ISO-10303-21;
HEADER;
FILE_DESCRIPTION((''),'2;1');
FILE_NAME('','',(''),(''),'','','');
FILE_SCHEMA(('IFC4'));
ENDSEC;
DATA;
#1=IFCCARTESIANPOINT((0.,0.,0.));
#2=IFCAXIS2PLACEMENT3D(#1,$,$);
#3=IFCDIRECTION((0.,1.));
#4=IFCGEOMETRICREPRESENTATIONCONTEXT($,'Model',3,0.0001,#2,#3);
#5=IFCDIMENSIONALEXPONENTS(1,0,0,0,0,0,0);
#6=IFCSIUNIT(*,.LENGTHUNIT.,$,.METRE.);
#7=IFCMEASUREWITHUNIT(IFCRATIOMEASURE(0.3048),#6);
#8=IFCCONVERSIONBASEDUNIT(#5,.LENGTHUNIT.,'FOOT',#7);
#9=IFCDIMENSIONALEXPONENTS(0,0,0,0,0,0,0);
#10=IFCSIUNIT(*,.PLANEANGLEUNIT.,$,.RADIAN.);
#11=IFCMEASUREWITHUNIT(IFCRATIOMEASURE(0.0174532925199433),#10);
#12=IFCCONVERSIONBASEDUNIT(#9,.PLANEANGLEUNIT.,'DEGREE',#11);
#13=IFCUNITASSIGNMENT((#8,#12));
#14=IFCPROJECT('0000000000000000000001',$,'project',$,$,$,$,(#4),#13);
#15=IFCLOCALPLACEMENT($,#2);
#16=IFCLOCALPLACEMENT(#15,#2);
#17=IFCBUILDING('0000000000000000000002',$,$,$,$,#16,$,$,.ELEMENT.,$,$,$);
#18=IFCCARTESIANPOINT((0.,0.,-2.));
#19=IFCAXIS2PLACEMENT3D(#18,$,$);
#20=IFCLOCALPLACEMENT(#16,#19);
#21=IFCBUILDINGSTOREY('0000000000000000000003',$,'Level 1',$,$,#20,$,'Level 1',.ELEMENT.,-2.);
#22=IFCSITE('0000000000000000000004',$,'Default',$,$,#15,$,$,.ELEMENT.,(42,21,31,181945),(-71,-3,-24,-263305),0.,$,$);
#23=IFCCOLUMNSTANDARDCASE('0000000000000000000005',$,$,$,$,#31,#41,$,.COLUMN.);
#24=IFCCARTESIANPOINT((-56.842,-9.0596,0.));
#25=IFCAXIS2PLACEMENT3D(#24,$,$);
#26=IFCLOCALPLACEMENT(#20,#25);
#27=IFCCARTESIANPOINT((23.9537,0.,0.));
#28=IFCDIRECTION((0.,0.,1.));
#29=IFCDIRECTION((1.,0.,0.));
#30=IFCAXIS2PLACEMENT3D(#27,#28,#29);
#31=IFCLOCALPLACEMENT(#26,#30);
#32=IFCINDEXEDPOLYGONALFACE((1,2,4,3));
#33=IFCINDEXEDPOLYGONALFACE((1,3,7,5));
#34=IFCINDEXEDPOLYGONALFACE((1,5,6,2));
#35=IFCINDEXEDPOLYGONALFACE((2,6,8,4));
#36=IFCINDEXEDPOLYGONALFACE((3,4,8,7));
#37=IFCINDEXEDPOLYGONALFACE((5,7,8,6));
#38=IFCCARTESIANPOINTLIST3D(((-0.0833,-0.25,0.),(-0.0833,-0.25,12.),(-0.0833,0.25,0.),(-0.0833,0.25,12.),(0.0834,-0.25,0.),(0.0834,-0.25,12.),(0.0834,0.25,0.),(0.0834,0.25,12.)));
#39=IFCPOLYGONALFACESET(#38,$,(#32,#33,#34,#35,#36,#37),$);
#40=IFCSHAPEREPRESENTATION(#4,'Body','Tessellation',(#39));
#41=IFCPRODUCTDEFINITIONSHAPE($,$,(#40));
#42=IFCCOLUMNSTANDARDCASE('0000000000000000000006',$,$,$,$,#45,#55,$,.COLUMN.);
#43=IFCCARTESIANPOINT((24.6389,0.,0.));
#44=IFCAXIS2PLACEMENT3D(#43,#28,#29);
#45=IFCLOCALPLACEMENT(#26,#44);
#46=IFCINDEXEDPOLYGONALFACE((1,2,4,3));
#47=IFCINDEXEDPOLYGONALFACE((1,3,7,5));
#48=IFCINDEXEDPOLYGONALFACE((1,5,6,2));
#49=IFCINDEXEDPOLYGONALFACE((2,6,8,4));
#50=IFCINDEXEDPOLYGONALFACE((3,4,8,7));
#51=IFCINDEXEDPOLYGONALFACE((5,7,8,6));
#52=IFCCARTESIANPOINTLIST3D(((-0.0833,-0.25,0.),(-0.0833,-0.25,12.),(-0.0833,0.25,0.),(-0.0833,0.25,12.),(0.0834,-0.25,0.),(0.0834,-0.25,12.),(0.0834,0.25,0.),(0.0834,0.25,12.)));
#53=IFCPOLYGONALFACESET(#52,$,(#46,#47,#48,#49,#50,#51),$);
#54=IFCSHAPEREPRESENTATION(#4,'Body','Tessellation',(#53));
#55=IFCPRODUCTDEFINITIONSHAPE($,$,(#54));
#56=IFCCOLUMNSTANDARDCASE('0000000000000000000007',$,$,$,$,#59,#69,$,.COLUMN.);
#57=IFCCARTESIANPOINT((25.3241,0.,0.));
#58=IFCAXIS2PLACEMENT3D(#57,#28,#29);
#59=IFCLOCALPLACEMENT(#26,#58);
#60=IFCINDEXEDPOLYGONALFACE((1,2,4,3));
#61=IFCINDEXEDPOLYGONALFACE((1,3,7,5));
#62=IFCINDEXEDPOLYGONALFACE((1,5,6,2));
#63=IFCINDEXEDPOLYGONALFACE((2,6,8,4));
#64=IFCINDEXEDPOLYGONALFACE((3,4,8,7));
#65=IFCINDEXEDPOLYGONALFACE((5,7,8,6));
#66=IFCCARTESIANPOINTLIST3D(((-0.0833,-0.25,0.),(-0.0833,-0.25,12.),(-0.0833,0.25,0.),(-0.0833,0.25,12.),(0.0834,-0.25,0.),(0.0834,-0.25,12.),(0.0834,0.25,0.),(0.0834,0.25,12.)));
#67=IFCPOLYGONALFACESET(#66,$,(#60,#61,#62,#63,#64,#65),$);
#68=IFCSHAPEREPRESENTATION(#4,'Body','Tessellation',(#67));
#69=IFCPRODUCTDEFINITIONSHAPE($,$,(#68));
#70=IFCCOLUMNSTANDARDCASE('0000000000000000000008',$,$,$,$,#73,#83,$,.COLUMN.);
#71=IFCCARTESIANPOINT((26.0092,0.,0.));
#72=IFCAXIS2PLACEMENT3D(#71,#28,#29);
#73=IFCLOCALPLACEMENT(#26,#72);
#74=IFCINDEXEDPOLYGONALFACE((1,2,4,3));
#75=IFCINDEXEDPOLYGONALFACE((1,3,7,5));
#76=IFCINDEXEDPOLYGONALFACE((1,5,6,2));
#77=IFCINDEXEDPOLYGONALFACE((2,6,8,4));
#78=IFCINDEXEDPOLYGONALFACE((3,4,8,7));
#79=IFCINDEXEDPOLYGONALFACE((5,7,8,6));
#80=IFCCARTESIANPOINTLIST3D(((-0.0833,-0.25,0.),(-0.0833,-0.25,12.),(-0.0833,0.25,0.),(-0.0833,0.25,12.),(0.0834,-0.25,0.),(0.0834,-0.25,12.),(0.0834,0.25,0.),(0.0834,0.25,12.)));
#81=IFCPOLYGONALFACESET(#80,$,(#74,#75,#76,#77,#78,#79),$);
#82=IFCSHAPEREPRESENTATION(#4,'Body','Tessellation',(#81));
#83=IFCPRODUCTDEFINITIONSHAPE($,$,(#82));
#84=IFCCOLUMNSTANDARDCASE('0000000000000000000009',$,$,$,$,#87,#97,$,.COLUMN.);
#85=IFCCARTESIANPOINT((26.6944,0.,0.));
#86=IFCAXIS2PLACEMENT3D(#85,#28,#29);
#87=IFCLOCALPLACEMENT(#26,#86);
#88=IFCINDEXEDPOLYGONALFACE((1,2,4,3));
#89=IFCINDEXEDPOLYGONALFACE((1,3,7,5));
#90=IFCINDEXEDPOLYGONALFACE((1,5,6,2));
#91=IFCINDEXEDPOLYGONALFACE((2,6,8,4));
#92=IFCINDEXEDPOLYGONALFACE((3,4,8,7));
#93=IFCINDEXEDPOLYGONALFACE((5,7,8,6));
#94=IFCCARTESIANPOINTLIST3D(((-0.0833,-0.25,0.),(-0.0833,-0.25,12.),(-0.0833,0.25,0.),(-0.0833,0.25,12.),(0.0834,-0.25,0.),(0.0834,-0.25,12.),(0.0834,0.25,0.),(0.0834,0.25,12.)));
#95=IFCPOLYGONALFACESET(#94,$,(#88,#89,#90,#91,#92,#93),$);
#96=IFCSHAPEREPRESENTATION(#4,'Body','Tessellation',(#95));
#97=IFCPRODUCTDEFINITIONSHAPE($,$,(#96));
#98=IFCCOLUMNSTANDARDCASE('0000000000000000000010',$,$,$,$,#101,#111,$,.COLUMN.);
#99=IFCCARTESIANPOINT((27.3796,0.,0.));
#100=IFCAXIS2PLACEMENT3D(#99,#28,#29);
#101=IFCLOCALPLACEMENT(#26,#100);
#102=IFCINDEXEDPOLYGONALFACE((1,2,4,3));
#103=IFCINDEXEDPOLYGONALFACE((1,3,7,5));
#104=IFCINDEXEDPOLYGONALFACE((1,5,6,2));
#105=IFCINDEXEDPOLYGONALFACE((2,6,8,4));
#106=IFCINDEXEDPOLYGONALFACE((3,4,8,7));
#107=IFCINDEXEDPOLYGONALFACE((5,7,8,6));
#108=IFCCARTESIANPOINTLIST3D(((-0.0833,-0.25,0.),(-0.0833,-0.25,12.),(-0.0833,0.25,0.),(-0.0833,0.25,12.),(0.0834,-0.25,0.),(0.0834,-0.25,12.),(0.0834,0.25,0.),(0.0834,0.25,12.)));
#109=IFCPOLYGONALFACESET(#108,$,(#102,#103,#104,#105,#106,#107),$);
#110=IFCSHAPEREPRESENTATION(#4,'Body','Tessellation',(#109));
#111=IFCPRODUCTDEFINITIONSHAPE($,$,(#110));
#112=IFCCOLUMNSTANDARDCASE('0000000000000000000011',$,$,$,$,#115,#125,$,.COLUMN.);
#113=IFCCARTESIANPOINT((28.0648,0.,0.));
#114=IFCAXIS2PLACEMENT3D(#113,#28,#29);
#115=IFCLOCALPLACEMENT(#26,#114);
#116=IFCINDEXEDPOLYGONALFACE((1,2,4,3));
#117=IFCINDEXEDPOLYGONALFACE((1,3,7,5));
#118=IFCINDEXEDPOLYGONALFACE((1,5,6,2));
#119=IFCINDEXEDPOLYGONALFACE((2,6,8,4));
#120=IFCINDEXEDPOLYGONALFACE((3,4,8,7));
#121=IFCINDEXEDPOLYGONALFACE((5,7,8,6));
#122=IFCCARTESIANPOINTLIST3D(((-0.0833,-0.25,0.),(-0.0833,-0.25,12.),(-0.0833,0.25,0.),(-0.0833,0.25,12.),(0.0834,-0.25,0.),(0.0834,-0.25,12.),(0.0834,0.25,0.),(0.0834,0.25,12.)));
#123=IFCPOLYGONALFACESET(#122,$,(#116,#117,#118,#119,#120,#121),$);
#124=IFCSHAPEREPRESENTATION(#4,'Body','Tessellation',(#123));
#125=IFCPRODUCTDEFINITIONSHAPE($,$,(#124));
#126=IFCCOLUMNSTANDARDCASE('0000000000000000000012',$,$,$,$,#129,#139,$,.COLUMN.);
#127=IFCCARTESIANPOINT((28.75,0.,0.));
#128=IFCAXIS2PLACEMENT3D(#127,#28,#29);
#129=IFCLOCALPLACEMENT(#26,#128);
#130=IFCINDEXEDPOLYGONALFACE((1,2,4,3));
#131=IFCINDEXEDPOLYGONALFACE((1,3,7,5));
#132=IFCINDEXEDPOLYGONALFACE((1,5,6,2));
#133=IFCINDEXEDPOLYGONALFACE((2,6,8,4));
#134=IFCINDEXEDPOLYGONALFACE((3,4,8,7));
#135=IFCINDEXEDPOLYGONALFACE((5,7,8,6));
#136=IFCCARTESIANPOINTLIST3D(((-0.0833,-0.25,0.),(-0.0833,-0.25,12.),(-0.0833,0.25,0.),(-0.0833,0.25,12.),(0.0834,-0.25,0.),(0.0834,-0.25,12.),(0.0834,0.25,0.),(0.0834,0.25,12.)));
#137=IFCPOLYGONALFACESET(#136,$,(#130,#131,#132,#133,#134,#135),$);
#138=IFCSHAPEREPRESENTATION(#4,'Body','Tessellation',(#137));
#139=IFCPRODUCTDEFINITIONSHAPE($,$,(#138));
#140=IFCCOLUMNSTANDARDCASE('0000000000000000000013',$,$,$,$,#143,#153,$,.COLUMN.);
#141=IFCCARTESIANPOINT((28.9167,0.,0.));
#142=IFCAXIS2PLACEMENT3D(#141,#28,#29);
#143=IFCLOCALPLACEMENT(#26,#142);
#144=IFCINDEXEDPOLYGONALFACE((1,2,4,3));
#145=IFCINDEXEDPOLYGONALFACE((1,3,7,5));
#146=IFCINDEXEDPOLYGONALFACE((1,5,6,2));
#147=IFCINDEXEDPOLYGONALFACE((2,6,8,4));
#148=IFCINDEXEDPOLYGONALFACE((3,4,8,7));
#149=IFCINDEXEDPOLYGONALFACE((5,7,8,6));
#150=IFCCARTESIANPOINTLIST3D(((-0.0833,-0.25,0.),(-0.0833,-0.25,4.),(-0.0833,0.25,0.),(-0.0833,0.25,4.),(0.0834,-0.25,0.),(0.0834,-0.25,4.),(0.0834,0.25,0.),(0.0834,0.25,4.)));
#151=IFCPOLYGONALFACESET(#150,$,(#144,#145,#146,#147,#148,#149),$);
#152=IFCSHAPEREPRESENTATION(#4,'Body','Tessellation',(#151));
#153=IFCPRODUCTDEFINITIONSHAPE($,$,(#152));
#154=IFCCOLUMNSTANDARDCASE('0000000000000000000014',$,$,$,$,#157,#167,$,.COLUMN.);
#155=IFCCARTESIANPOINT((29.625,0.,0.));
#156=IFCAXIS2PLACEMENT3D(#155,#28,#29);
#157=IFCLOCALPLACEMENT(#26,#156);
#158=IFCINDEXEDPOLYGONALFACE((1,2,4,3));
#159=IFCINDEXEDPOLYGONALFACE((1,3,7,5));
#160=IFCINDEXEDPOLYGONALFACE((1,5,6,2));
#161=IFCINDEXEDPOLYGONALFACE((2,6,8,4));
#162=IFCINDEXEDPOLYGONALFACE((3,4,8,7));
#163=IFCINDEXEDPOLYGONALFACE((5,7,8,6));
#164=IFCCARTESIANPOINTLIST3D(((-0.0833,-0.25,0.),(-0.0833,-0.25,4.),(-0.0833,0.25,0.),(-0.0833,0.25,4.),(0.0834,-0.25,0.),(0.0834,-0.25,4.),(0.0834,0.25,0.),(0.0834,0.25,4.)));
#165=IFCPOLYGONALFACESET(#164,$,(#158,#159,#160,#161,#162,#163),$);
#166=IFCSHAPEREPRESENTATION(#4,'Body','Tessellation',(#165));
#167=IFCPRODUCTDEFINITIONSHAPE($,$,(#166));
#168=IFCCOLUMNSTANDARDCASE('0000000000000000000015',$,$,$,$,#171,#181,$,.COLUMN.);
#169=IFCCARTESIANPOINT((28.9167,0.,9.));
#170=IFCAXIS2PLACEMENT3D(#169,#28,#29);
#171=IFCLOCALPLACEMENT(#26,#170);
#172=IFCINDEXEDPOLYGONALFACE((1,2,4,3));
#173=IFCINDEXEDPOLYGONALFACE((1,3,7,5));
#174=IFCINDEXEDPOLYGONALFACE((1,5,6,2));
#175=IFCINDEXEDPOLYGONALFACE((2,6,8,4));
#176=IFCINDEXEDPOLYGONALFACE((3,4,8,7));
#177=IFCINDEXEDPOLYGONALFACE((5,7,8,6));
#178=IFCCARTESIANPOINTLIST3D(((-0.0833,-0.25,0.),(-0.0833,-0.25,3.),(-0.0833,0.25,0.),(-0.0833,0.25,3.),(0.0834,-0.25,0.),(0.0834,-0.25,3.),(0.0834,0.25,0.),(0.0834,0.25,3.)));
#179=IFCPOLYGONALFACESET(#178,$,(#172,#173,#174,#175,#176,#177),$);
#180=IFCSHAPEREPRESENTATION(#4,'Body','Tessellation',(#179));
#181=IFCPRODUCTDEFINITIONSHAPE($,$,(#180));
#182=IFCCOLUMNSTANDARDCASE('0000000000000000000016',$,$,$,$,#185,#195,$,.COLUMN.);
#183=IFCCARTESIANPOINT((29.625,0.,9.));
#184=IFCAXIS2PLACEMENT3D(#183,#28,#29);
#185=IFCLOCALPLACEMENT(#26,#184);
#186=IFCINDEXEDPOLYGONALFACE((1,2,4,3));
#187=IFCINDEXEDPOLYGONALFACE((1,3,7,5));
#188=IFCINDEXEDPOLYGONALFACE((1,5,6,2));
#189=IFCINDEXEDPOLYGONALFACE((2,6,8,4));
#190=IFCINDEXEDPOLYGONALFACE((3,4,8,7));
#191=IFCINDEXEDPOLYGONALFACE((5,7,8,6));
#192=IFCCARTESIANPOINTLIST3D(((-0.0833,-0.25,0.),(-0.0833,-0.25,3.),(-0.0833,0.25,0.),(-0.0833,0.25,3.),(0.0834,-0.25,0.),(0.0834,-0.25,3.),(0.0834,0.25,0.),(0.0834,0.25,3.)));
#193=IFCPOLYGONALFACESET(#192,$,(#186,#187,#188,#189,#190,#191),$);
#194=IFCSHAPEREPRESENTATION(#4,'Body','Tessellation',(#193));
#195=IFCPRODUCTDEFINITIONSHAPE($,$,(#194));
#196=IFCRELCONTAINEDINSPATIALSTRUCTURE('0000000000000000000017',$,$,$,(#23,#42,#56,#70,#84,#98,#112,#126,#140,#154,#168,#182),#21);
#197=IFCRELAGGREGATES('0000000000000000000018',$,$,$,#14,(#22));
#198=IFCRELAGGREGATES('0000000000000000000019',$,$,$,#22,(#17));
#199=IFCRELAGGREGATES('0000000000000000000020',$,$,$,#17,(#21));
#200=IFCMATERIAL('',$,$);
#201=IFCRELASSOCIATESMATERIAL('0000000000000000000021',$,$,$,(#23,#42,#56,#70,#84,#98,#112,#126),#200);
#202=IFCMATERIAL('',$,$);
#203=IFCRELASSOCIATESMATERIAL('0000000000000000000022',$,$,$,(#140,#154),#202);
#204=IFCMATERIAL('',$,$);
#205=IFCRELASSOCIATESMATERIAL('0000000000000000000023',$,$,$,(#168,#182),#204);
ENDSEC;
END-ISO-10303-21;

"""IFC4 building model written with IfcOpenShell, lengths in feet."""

from ifc_helpers import new_model, entity, si_unit, converted_unit, direction, frame, origin, place, context, project, spatial, rectangle, extrude, material, element, save


model = new_model("IFC4")

# Units and contexts
model_context = context("Model", 3, precision=0.0001, world=origin(), true_north=direction((0.0, 1.0)))
ifc_project = project(units=[converted_unit("LENGTHUNIT", "FOOT", entity("IfcRatioMeasure", 0.3048), si_unit("LENGTHUNIT", "METRE"), dimensions=[1, 0, 0, 0, 0, 0, 0]), converted_unit("PLANEANGLEUNIT", "DEGREE", entity("IfcRatioMeasure", 0.0174532925199433), si_unit("PLANEANGLEUNIT", "RADIAN"), dimensions=[0, 0, 0, 0, 0, 0, 0])], contexts=[model_context])

# Site, building, storey
site_placement = place(None, origin())
site = spatial("IfcSite", under=ifc_project, at=site_placement, Name="Default", CompositionType="ELEMENT", RefLatitude=(42, 21, 31, 181945), RefLongitude=(-71, -3, -24, -263305), RefElevation=0.0)
building_placement = place(site_placement, origin())
building = spatial("IfcBuilding", under=site, at=building_placement, CompositionType="ELEMENT")
storey_placement = place(building_placement, frame((0.0, 0.0, -2.0)))
storey = spatial("IfcBuildingStorey", under=building, at=storey_placement, Name="Level 1", LongName="Level 1", CompositionType="ELEMENT", Elevation=-2.0)

# Columns
ifc_material_1 = material(Name="")
placement = place(storey_placement, frame((-56.842, -9.0596, 0.0)))
for number, where, z_axis, x_axis in (
    (1, (23.9537, 0.0, 0.0), (0.0, 0.0, 1.0), (1.0, 0.0, 0.0)),
    (2, (24.6389, 0.0, 0.0), (0.0, 0.0, 1.0), (1.0, 0.0, 0.0)),
    (3, (25.3241, 0.0, 0.0), (0.0, 0.0, 1.0), (1.0, 0.0, 0.0)),
    (4, (26.0092, 0.0, 0.0), (0.0, 0.0, 1.0), (1.0, 0.0, 0.0)),
    (5, (26.6944, 0.0, 0.0), (0.0, 0.0, 1.0), (1.0, 0.0, 0.0)),
    (6, (27.3796, 0.0, 0.0), (0.0, 0.0, 1.0), (1.0, 0.0, 0.0)),
    (7, (28.0648, 0.0, 0.0), (0.0, 0.0, 1.0), (1.0, 0.0, 0.0)),
    (8, (28.75, 0.0, 0.0), (0.0, 0.0, 1.0), (1.0, 0.0, 0.0)),
):
    element("IfcColumnStandardCase", number, at=place(placement, frame(where, z_axis=z_axis, x_axis=x_axis)), inside=storey, material=ifc_material_1, PredefinedType="COLUMN", context=model_context, shape_type="SweptSolid", body=[
        extrude(rectangle(XDim=0.1667, YDim=0.5), origin(), (0.0, 0.0, 1.0), 12.0),
    ])
ifc_material_2 = material(Name="")
for number, where, z_axis, x_axis in (
    (9, (28.9167, 0.0, 0.0), (0.0, 0.0, 1.0), (1.0, 0.0, 0.0)),
    (10, (29.625, 0.0, 0.0), (0.0, 0.0, 1.0), (1.0, 0.0, 0.0)),
):
    element("IfcColumnStandardCase", number, at=place(placement, frame(where, z_axis=z_axis, x_axis=x_axis)), inside=storey, material=ifc_material_2, PredefinedType="COLUMN", context=model_context, shape_type="SweptSolid", body=[
        extrude(rectangle(XDim=0.1667, YDim=0.5), origin(), (0.0, 0.0, 1.0), 4.0),
    ])
ifc_material_3 = material(Name="")
for number, where, z_axis, x_axis in (
    (11, (28.9167, 0.0, 9.0), (0.0, 0.0, 1.0), (1.0, 0.0, 0.0)),
    (12, (29.625, 0.0, 9.0), (0.0, 0.0, 1.0), (1.0, 0.0, 0.0)),
):
    element("IfcColumnStandardCase", number, at=place(placement, frame(where, z_axis=z_axis, x_axis=x_axis)), inside=storey, material=ifc_material_3, PredefinedType="COLUMN", context=model_context, shape_type="SweptSolid", body=[
        extrude(rectangle(XDim=0.1667, YDim=0.5), origin(), (0.0, 0.0, 1.0), 3.0),
    ])

save(model, "model.ifc")
